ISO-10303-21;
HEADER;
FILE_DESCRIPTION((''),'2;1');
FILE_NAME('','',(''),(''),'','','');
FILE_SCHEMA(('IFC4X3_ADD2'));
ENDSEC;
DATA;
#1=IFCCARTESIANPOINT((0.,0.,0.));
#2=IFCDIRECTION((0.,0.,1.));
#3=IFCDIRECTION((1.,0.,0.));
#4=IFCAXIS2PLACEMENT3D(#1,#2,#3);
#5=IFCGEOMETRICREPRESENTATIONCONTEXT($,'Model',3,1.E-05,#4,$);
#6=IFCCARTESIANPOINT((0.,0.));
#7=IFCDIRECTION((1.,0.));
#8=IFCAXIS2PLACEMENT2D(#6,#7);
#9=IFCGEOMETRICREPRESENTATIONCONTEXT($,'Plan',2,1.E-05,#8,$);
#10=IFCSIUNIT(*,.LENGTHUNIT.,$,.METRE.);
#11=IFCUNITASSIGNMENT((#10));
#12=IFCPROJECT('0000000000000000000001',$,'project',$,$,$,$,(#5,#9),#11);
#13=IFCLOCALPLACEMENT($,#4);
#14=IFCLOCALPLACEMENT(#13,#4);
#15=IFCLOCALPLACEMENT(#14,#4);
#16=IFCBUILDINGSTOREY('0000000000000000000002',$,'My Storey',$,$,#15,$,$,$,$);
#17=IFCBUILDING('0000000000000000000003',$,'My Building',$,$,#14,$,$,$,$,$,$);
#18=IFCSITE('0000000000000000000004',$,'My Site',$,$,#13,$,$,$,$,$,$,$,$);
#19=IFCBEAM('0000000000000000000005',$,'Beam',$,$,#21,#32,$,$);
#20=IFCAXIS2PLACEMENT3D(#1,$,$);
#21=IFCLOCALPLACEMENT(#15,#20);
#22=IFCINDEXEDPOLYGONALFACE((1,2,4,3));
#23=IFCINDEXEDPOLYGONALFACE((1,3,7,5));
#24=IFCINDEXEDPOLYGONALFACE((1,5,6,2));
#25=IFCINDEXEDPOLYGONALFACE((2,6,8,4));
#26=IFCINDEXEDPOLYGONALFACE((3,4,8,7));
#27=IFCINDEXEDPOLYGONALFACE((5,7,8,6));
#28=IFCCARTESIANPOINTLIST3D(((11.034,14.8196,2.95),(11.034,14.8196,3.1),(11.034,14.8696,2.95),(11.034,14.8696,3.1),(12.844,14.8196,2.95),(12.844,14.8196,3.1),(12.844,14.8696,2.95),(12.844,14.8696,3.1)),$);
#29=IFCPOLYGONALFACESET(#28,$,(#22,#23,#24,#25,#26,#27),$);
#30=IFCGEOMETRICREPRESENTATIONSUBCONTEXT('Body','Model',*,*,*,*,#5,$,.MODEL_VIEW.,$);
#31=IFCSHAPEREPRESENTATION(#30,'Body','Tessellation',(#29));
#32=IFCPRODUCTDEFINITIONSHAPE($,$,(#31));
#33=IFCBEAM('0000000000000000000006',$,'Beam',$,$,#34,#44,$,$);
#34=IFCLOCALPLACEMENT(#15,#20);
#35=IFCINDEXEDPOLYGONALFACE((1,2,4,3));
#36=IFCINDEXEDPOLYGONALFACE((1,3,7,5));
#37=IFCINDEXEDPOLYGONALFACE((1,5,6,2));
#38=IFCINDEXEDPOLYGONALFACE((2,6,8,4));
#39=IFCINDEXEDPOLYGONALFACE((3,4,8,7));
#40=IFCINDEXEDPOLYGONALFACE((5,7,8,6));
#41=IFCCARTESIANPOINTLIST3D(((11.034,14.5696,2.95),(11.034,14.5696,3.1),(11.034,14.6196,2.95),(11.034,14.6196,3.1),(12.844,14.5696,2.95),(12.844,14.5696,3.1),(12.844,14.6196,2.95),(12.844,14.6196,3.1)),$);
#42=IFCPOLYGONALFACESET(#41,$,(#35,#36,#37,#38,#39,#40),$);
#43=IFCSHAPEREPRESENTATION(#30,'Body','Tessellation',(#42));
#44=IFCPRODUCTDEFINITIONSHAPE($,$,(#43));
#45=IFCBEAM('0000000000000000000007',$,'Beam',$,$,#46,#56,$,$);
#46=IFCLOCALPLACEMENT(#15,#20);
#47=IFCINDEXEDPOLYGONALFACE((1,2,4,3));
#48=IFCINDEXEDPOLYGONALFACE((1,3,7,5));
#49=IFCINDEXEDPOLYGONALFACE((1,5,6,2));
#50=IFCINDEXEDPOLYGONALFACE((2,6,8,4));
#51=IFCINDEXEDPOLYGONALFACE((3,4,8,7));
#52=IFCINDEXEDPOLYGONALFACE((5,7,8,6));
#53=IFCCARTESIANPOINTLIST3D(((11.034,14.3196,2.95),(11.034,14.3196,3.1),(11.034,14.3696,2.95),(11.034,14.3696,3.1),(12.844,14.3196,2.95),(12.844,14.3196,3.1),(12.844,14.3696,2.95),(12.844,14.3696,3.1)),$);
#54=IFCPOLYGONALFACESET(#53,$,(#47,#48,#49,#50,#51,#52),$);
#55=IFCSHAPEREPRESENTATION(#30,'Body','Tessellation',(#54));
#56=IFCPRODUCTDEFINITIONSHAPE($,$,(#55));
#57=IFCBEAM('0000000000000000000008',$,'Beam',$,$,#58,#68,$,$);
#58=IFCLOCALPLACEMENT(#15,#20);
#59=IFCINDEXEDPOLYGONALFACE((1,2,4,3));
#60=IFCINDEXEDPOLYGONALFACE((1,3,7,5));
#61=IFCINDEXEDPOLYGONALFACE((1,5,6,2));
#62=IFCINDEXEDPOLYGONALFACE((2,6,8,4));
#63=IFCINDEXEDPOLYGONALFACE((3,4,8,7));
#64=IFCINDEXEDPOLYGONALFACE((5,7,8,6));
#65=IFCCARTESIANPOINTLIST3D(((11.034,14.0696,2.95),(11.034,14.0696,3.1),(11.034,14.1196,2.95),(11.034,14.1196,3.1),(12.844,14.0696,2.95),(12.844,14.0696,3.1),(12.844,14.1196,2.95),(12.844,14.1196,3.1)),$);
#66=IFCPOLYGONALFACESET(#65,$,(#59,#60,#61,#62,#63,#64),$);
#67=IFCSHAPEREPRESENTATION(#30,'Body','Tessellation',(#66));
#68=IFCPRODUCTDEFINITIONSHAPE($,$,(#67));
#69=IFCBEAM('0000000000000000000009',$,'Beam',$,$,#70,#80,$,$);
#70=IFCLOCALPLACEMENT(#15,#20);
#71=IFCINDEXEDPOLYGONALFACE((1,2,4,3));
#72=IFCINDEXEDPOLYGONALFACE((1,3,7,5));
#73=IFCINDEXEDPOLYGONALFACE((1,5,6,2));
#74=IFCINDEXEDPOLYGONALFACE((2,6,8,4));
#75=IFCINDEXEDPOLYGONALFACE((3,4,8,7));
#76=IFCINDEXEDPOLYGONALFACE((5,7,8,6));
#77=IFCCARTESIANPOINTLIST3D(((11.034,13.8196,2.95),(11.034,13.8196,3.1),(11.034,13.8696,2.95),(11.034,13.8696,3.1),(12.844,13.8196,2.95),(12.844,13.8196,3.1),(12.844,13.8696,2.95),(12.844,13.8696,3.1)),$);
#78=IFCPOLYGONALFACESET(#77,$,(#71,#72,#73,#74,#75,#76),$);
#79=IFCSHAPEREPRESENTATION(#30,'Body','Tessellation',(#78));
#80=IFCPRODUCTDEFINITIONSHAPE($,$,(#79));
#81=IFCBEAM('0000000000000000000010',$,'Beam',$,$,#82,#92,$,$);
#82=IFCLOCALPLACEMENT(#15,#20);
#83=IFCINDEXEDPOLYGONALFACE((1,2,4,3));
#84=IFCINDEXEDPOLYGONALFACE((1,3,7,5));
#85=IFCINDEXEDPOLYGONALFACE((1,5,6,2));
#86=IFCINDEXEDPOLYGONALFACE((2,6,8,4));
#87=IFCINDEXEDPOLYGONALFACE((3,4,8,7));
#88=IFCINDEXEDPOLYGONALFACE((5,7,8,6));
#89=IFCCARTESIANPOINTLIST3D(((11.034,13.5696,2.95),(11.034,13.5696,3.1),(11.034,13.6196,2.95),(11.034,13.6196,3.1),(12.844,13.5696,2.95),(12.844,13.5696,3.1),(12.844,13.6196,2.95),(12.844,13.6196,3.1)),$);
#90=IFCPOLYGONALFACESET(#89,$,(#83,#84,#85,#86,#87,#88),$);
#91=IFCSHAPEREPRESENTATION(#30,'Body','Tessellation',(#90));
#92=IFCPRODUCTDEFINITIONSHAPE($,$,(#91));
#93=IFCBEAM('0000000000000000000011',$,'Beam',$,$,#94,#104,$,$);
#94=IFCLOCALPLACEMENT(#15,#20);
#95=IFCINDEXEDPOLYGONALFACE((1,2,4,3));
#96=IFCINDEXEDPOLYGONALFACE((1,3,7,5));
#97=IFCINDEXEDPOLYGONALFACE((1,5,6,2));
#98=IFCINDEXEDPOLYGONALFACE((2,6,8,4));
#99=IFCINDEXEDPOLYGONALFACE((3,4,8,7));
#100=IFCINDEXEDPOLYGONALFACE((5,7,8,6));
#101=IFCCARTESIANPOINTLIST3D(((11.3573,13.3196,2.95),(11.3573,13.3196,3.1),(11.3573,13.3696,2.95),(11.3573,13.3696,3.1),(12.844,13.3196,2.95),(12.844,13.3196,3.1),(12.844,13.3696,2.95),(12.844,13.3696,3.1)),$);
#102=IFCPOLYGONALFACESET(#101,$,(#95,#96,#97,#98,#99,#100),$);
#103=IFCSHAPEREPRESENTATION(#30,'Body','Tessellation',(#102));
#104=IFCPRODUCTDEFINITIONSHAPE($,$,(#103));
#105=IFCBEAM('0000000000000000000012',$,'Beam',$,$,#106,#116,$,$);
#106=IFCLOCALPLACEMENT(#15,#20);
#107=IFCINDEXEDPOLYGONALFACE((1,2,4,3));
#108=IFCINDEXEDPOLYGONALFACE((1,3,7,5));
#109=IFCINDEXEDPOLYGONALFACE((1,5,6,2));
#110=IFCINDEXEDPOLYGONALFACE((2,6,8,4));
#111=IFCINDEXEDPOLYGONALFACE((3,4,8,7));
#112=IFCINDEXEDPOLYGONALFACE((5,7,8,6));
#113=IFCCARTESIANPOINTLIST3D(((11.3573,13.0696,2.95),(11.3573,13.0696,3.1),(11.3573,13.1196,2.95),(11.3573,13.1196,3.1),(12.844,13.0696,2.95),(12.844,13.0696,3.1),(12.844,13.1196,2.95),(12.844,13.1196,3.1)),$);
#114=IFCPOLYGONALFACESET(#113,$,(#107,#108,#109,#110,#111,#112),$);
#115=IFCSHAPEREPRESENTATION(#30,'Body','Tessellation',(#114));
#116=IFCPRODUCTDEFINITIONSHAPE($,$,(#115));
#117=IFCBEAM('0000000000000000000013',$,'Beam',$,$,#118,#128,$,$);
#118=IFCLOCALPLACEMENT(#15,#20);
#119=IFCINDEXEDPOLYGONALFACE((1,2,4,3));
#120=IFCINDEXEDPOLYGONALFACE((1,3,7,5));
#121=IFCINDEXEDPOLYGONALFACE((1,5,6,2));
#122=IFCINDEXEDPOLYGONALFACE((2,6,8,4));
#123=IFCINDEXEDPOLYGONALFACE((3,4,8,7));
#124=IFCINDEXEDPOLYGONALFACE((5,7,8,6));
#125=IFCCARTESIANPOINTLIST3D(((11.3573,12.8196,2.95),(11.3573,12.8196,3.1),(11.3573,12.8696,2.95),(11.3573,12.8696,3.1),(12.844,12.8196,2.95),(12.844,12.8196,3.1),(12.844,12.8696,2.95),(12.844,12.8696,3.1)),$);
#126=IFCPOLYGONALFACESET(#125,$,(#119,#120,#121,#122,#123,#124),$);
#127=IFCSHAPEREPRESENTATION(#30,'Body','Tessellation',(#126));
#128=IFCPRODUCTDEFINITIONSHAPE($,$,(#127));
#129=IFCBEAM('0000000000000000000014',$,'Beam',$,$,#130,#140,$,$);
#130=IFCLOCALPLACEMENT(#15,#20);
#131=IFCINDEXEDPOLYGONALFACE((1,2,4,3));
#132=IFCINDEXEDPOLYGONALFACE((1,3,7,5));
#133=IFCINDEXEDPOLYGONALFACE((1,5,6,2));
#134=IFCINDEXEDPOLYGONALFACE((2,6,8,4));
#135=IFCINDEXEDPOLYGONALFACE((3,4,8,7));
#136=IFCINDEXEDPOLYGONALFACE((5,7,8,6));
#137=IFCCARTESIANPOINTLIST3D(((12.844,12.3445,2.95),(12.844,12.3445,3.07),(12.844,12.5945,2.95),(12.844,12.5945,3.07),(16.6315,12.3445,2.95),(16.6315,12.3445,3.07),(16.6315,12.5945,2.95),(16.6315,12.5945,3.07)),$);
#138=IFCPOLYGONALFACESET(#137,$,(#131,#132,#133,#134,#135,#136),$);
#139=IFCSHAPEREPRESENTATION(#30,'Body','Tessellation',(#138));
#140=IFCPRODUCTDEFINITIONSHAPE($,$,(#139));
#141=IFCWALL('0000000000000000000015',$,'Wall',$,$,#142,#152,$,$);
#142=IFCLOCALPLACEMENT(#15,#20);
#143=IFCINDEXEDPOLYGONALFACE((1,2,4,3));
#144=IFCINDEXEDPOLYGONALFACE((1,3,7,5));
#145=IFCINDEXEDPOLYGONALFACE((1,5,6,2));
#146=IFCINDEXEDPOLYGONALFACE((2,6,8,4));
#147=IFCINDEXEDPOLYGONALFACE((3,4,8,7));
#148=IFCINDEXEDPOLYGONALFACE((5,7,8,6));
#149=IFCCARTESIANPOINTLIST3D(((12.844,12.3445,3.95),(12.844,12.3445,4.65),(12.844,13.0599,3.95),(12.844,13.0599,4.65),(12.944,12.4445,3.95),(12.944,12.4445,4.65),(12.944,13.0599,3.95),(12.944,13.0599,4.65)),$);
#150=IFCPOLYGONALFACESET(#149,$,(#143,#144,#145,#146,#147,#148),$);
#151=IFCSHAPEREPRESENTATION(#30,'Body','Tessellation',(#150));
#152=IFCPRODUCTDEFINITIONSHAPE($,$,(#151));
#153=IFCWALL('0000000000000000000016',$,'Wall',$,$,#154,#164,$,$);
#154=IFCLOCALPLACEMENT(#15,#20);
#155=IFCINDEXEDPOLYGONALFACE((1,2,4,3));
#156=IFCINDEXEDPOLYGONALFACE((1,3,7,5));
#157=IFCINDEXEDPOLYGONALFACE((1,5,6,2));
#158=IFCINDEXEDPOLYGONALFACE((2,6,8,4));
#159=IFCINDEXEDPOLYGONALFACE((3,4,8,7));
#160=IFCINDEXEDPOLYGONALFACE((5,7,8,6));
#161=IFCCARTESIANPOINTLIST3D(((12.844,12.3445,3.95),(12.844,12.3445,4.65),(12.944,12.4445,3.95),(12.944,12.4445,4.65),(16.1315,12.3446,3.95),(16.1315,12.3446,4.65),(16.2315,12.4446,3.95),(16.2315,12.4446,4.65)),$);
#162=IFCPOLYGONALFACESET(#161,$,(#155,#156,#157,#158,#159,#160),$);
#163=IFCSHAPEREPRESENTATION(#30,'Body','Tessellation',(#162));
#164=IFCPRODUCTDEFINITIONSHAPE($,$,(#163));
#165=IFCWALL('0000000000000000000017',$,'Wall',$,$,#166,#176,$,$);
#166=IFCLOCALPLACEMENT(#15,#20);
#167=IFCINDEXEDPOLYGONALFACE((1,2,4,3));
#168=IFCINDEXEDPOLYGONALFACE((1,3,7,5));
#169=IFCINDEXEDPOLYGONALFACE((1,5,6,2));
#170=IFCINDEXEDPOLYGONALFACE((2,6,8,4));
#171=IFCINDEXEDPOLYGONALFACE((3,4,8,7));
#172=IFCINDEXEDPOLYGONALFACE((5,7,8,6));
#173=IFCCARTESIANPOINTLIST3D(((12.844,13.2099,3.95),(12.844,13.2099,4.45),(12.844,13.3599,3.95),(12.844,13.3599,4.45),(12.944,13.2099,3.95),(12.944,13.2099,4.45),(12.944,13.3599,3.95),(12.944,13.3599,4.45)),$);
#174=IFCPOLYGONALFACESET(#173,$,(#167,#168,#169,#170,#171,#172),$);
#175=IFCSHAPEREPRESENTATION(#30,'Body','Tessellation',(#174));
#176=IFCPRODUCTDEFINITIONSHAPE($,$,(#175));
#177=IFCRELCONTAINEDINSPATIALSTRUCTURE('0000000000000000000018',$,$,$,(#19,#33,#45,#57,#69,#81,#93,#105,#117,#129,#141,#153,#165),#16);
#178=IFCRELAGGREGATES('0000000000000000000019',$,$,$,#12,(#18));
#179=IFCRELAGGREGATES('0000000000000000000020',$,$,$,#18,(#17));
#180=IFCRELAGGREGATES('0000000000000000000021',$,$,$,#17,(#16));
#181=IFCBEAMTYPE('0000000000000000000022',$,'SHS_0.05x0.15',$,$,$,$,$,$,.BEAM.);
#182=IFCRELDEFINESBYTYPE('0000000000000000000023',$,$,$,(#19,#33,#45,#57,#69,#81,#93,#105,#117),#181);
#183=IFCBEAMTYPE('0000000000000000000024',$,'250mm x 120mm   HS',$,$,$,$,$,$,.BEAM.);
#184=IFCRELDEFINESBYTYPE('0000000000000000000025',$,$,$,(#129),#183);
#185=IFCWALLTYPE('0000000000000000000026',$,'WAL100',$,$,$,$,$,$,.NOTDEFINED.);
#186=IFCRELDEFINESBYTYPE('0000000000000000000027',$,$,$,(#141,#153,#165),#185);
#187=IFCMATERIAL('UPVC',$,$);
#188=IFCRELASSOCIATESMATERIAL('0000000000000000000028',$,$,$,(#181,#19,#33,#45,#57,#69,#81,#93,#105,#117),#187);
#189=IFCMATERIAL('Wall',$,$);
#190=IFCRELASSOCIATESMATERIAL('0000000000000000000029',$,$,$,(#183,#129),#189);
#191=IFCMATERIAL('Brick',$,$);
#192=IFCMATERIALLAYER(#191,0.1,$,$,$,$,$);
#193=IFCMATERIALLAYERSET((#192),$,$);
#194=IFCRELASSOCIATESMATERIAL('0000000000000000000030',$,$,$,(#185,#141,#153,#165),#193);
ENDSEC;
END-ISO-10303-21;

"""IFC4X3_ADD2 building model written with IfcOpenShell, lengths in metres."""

from ifc_helpers import new_model, si_unit, frame, origin_with_axes, origin_2d_with_axis, place, context, subcontext, project, spatial, line, indexed_curve, rectangle, outline, extrude, material, layer, layer_set, layer_usage, material_profile, profile_set, profile_usage, type_object, element, save


model = new_model("IFC4X3_ADD2")

# Units and contexts
model_context = context("Model", 3, precision=1e-05, world=origin_with_axes())
plan_context = context("Plan", 2, precision=1e-05, world=origin_2d_with_axis())
body_context = subcontext(model_context, "Body", "Model", "MODEL_VIEW")
ifc_project = project(units=[si_unit("LENGTHUNIT", "METRE")], contexts=[model_context, plan_context])

# Site, building, storey
site_placement = place(None, origin_with_axes())
site = spatial("IfcSite", under=ifc_project, at=site_placement, Name="My Site")
building_placement = place(site_placement, origin_with_axes())
building = spatial("IfcBuilding", under=site, at=building_placement, Name="My Building")
storey_placement = place(building_placement, origin_with_axes())
storey = spatial("IfcBuildingStorey", under=building, at=storey_placement, Name="My Storey")

# Beams
ifc_material_1 = material(Name="UPVC")
ifc_material_profile_1 = material_profile(ifc_material_1, outline(indexed_curve([(-0.025, 0.075), (0.025, 0.075), (0.025, -0.075), (-0.025, -0.075), (-0.025, 0.075)])))
ifc_profile_set_1 = profile_set([ifc_material_profile_1])
ifc_profile_usage_1 = profile_usage(ifc_profile_set_1, cardinal=5)
beam_type_1 = type_object("IfcBeamType", Name="SHS_0.05x0.15", PredefinedType="BEAM", material=ifc_profile_set_1)
beam_1_placement = place(storey_placement, frame((12.844, 14.8446, 3.025), z_axis=(-1.0, 0.0, 0.0), x_axis=(0.0, -1.0, 0.0)))
element("IfcBeam", 1, at=beam_1_placement, inside=storey, type_object=beam_type_1, material=ifc_profile_usage_1, Name="Beam", context=body_context, shape_type="SweptSolid", body=[
    extrude(outline(indexed_curve([(-0.025, 0.075), (0.025, 0.075), (0.025, -0.075), (-0.025, -0.075), (-0.025, 0.075)])), origin_with_axes(), (0.0, 0.0, 1.0), 1.81),
])
ifc_profile_usage_2 = profile_usage(ifc_profile_set_1, cardinal=5)
beam_2_placement = place(storey_placement, frame((12.844, 14.5946, 3.025), z_axis=(-1.0, 0.0, 0.0), x_axis=(0.0, -1.0, 0.0)))
element("IfcBeam", 2, at=beam_2_placement, inside=storey, type_object=beam_type_1, material=ifc_profile_usage_2, Name="Beam", context=body_context, shape_type="SweptSolid", body=[
    extrude(outline(indexed_curve([(-0.025, 0.075), (0.025, 0.075), (0.025, -0.075), (-0.025, -0.075), (-0.025, 0.075)])), origin_with_axes(), (0.0, 0.0, 1.0), 1.81),
])
ifc_profile_usage_3 = profile_usage(ifc_profile_set_1, cardinal=5)
beam_3_placement = place(storey_placement, frame((12.844, 14.3446, 3.025), z_axis=(-1.0, 0.0, 0.0), x_axis=(0.0, -1.0, 0.0)))
element("IfcBeam", 3, at=beam_3_placement, inside=storey, type_object=beam_type_1, material=ifc_profile_usage_3, Name="Beam", context=body_context, shape_type="SweptSolid", body=[
    extrude(outline(indexed_curve([(-0.025, 0.075), (0.025, 0.075), (0.025, -0.075), (-0.025, -0.075), (-0.025, 0.075)])), origin_with_axes(), (0.0, 0.0, 1.0), 1.81),
])
ifc_profile_usage_4 = profile_usage(ifc_profile_set_1, cardinal=5)
beam_4_placement = place(storey_placement, frame((12.844, 14.0946, 3.025), z_axis=(-1.0, 0.0, 0.0), x_axis=(0.0, -1.0, 0.0)))
element("IfcBeam", 4, at=beam_4_placement, inside=storey, type_object=beam_type_1, material=ifc_profile_usage_4, Name="Beam", context=body_context, shape_type="SweptSolid", body=[
    extrude(outline(indexed_curve([(-0.025, 0.075), (0.025, 0.075), (0.025, -0.075), (-0.025, -0.075), (-0.025, 0.075)])), origin_with_axes(), (0.0, 0.0, 1.0), 1.81),
])
ifc_profile_usage_5 = profile_usage(ifc_profile_set_1, cardinal=5)
beam_5_placement = place(storey_placement, frame((12.844, 13.8446, 3.025), z_axis=(-1.0, 0.0, 0.0), x_axis=(0.0, -1.0, 0.0)))
element("IfcBeam", 5, at=beam_5_placement, inside=storey, type_object=beam_type_1, material=ifc_profile_usage_5, Name="Beam", context=body_context, shape_type="SweptSolid", body=[
    extrude(outline(indexed_curve([(-0.025, 0.075), (0.025, 0.075), (0.025, -0.075), (-0.025, -0.075), (-0.025, 0.075)])), origin_with_axes(), (0.0, 0.0, 1.0), 1.81),
])
ifc_profile_usage_6 = profile_usage(ifc_profile_set_1, cardinal=5)
beam_6_placement = place(storey_placement, frame((12.844, 13.5946, 3.025), z_axis=(-1.0, 0.0, 0.0), x_axis=(0.0, -1.0, 0.0)))
element("IfcBeam", 6, at=beam_6_placement, inside=storey, type_object=beam_type_1, material=ifc_profile_usage_6, Name="Beam", context=body_context, shape_type="SweptSolid", body=[
    extrude(outline(indexed_curve([(-0.025, 0.075), (0.025, 0.075), (0.025, -0.075), (-0.025, -0.075), (-0.025, 0.075)])), origin_with_axes(), (0.0, 0.0, 1.0), 1.81),
])
ifc_profile_usage_7 = profile_usage(ifc_profile_set_1, cardinal=5)
beam_7_placement = place(storey_placement, frame((12.844, 13.3446, 3.025), z_axis=(-1.0, 0.0, 0.0), x_axis=(0.0, -1.0, 0.0)))
element("IfcBeam", 7, at=beam_7_placement, inside=storey, type_object=beam_type_1, material=ifc_profile_usage_7, Name="Beam", context=body_context, shape_type="SweptSolid", body=[
    extrude(outline(indexed_curve([(-0.025, 0.075), (0.025, 0.075), (0.025, -0.075), (-0.025, -0.075), (-0.025, 0.075)])), origin_with_axes(), (0.0, 0.0, 1.0), 1.4867),
])
ifc_profile_usage_8 = profile_usage(ifc_profile_set_1, cardinal=5)
beam_8_placement = place(storey_placement, frame((12.844, 13.0946, 3.025), z_axis=(-1.0, 0.0, 0.0), x_axis=(0.0, -1.0, 0.0)))
element("IfcBeam", 8, at=beam_8_placement, inside=storey, type_object=beam_type_1, material=ifc_profile_usage_8, Name="Beam", context=body_context, shape_type="SweptSolid", body=[
    extrude(outline(indexed_curve([(-0.025, 0.075), (0.025, 0.075), (0.025, -0.075), (-0.025, -0.075), (-0.025, 0.075)])), origin_with_axes(), (0.0, 0.0, 1.0), 1.4867),
])
ifc_profile_usage_9 = profile_usage(ifc_profile_set_1, cardinal=5)
beam_9_placement = place(storey_placement, frame((12.844, 12.8446, 3.025), z_axis=(-1.0, 0.0, 0.0), x_axis=(0.0, -1.0, 0.0)))
element("IfcBeam", 9, at=beam_9_placement, inside=storey, type_object=beam_type_1, material=ifc_profile_usage_9, Name="Beam", context=body_context, shape_type="SweptSolid", body=[
    extrude(outline(indexed_curve([(-0.025, 0.075), (0.025, 0.075), (0.025, -0.075), (-0.025, -0.075), (-0.025, 0.075)])), origin_with_axes(), (0.0, 0.0, 1.0), 1.4867),
])
ifc_material_2 = material(Name="Wall")
ifc_material_profile_2 = material_profile(ifc_material_2, rectangle(XDim=0.25, YDim=0.12))
ifc_profile_set_2 = profile_set([ifc_material_profile_2], Name="concrete")
ifc_profile_usage_10 = profile_usage(ifc_profile_set_2, cardinal=5)
beam_type_2 = type_object("IfcBeamType", Name="250mm x 120mm   HS", PredefinedType="BEAM", material=ifc_profile_set_2)
beam_10_placement = place(storey_placement, frame((12.844, 12.4695, 3.01), z_axis=(1.0, 0.0, 0.0), x_axis=(0.0, 1.0, 0.0)))
element("IfcBeam", 10, at=beam_10_placement, inside=storey, type_object=beam_type_2, material=ifc_profile_usage_10, Name="Beam", context=body_context, shape_type="SweptSolid", body=[
    extrude(rectangle(XDim=0.25, YDim=0.12), origin_with_axes(), (0.0, 0.0, 1.0), 3.7875),
])

# Walls
ifc_material_3 = material(Name="Brick")
ifc_layer_1 = layer(ifc_material_3, 0.1)
ifc_layer_set_1 = layer_set([ifc_layer_1])
ifc_layer_usage_1 = layer_usage(ifc_layer_set_1, "AXIS2", "POSITIVE", 0.0)
wall_type_1 = type_object("IfcWallType", Name="WAL100", PredefinedType="NOTDEFINED", material=ifc_layer_set_1)
wall_1_placement = place(storey_placement, frame((12.944, 12.3445, 3.95), z_axis=(0.0, 0.0, 1.0), x_axis=(-0.000005, 1.0, 0.0)))
element("IfcWall", 11, at=wall_1_placement, inside=storey, type_object=wall_type_1, material=ifc_layer_usage_1, Name="Wall", context=body_context, shape_type="SweptSolid", body=[
    extrude(outline(indexed_curve([(0.1, 0.0), (0.0, 0.1), (0.7154, 0.1), (0.7154, 0.0)], segments=[line(1, 2, 3, 4, 1)])), origin_with_axes(), (0.0, 0.0, 1.0), 0.7),
])
ifc_layer_usage_2 = layer_usage(ifc_layer_set_1, "AXIS2", "POSITIVE", 0.0)
wall_2_placement = place(storey_placement, frame((12.944, 12.3445, 3.95), z_axis=(0.0, 0.0, 1.0), x_axis=(1.0, 0.000005, 0.0)))
element("IfcWall", 12, at=wall_2_placement, inside=storey, type_object=wall_type_1, material=ifc_layer_usage_2, Name="Wall", context=body_context, shape_type="SweptSolid", body=[
    extrude(outline(indexed_curve([(-0.1, 0.0), (0.0, 0.1), (3.2874, 0.1), (3.1874, 0.0)], segments=[line(1, 2, 3, 4, 1)])), origin_with_axes(), (0.0, 0.0, 1.0), 0.7),
])
ifc_layer_usage_3 = layer_usage(ifc_layer_set_1, "AXIS2", "POSITIVE", 0.0)
wall_3_placement = place(storey_placement, frame((12.944, 13.2099, 3.95), z_axis=(0.0, 0.0, 1.0), x_axis=(-0.000005, 1.0, 0.0)))
element("IfcWall", 13, at=wall_3_placement, inside=storey, type_object=wall_type_1, material=ifc_layer_usage_3, Name="Wall", context=body_context, shape_type="SweptSolid", body=[
    extrude(outline(indexed_curve([(0.0, 0.0), (0.0, 0.1), (0.15, 0.1), (0.15, 0.0)], segments=[line(1, 2, 3, 4, 1)])), origin_with_axes(), (0.0, 0.0, 1.0), 0.5),
])

save(model, "model.ifc")
